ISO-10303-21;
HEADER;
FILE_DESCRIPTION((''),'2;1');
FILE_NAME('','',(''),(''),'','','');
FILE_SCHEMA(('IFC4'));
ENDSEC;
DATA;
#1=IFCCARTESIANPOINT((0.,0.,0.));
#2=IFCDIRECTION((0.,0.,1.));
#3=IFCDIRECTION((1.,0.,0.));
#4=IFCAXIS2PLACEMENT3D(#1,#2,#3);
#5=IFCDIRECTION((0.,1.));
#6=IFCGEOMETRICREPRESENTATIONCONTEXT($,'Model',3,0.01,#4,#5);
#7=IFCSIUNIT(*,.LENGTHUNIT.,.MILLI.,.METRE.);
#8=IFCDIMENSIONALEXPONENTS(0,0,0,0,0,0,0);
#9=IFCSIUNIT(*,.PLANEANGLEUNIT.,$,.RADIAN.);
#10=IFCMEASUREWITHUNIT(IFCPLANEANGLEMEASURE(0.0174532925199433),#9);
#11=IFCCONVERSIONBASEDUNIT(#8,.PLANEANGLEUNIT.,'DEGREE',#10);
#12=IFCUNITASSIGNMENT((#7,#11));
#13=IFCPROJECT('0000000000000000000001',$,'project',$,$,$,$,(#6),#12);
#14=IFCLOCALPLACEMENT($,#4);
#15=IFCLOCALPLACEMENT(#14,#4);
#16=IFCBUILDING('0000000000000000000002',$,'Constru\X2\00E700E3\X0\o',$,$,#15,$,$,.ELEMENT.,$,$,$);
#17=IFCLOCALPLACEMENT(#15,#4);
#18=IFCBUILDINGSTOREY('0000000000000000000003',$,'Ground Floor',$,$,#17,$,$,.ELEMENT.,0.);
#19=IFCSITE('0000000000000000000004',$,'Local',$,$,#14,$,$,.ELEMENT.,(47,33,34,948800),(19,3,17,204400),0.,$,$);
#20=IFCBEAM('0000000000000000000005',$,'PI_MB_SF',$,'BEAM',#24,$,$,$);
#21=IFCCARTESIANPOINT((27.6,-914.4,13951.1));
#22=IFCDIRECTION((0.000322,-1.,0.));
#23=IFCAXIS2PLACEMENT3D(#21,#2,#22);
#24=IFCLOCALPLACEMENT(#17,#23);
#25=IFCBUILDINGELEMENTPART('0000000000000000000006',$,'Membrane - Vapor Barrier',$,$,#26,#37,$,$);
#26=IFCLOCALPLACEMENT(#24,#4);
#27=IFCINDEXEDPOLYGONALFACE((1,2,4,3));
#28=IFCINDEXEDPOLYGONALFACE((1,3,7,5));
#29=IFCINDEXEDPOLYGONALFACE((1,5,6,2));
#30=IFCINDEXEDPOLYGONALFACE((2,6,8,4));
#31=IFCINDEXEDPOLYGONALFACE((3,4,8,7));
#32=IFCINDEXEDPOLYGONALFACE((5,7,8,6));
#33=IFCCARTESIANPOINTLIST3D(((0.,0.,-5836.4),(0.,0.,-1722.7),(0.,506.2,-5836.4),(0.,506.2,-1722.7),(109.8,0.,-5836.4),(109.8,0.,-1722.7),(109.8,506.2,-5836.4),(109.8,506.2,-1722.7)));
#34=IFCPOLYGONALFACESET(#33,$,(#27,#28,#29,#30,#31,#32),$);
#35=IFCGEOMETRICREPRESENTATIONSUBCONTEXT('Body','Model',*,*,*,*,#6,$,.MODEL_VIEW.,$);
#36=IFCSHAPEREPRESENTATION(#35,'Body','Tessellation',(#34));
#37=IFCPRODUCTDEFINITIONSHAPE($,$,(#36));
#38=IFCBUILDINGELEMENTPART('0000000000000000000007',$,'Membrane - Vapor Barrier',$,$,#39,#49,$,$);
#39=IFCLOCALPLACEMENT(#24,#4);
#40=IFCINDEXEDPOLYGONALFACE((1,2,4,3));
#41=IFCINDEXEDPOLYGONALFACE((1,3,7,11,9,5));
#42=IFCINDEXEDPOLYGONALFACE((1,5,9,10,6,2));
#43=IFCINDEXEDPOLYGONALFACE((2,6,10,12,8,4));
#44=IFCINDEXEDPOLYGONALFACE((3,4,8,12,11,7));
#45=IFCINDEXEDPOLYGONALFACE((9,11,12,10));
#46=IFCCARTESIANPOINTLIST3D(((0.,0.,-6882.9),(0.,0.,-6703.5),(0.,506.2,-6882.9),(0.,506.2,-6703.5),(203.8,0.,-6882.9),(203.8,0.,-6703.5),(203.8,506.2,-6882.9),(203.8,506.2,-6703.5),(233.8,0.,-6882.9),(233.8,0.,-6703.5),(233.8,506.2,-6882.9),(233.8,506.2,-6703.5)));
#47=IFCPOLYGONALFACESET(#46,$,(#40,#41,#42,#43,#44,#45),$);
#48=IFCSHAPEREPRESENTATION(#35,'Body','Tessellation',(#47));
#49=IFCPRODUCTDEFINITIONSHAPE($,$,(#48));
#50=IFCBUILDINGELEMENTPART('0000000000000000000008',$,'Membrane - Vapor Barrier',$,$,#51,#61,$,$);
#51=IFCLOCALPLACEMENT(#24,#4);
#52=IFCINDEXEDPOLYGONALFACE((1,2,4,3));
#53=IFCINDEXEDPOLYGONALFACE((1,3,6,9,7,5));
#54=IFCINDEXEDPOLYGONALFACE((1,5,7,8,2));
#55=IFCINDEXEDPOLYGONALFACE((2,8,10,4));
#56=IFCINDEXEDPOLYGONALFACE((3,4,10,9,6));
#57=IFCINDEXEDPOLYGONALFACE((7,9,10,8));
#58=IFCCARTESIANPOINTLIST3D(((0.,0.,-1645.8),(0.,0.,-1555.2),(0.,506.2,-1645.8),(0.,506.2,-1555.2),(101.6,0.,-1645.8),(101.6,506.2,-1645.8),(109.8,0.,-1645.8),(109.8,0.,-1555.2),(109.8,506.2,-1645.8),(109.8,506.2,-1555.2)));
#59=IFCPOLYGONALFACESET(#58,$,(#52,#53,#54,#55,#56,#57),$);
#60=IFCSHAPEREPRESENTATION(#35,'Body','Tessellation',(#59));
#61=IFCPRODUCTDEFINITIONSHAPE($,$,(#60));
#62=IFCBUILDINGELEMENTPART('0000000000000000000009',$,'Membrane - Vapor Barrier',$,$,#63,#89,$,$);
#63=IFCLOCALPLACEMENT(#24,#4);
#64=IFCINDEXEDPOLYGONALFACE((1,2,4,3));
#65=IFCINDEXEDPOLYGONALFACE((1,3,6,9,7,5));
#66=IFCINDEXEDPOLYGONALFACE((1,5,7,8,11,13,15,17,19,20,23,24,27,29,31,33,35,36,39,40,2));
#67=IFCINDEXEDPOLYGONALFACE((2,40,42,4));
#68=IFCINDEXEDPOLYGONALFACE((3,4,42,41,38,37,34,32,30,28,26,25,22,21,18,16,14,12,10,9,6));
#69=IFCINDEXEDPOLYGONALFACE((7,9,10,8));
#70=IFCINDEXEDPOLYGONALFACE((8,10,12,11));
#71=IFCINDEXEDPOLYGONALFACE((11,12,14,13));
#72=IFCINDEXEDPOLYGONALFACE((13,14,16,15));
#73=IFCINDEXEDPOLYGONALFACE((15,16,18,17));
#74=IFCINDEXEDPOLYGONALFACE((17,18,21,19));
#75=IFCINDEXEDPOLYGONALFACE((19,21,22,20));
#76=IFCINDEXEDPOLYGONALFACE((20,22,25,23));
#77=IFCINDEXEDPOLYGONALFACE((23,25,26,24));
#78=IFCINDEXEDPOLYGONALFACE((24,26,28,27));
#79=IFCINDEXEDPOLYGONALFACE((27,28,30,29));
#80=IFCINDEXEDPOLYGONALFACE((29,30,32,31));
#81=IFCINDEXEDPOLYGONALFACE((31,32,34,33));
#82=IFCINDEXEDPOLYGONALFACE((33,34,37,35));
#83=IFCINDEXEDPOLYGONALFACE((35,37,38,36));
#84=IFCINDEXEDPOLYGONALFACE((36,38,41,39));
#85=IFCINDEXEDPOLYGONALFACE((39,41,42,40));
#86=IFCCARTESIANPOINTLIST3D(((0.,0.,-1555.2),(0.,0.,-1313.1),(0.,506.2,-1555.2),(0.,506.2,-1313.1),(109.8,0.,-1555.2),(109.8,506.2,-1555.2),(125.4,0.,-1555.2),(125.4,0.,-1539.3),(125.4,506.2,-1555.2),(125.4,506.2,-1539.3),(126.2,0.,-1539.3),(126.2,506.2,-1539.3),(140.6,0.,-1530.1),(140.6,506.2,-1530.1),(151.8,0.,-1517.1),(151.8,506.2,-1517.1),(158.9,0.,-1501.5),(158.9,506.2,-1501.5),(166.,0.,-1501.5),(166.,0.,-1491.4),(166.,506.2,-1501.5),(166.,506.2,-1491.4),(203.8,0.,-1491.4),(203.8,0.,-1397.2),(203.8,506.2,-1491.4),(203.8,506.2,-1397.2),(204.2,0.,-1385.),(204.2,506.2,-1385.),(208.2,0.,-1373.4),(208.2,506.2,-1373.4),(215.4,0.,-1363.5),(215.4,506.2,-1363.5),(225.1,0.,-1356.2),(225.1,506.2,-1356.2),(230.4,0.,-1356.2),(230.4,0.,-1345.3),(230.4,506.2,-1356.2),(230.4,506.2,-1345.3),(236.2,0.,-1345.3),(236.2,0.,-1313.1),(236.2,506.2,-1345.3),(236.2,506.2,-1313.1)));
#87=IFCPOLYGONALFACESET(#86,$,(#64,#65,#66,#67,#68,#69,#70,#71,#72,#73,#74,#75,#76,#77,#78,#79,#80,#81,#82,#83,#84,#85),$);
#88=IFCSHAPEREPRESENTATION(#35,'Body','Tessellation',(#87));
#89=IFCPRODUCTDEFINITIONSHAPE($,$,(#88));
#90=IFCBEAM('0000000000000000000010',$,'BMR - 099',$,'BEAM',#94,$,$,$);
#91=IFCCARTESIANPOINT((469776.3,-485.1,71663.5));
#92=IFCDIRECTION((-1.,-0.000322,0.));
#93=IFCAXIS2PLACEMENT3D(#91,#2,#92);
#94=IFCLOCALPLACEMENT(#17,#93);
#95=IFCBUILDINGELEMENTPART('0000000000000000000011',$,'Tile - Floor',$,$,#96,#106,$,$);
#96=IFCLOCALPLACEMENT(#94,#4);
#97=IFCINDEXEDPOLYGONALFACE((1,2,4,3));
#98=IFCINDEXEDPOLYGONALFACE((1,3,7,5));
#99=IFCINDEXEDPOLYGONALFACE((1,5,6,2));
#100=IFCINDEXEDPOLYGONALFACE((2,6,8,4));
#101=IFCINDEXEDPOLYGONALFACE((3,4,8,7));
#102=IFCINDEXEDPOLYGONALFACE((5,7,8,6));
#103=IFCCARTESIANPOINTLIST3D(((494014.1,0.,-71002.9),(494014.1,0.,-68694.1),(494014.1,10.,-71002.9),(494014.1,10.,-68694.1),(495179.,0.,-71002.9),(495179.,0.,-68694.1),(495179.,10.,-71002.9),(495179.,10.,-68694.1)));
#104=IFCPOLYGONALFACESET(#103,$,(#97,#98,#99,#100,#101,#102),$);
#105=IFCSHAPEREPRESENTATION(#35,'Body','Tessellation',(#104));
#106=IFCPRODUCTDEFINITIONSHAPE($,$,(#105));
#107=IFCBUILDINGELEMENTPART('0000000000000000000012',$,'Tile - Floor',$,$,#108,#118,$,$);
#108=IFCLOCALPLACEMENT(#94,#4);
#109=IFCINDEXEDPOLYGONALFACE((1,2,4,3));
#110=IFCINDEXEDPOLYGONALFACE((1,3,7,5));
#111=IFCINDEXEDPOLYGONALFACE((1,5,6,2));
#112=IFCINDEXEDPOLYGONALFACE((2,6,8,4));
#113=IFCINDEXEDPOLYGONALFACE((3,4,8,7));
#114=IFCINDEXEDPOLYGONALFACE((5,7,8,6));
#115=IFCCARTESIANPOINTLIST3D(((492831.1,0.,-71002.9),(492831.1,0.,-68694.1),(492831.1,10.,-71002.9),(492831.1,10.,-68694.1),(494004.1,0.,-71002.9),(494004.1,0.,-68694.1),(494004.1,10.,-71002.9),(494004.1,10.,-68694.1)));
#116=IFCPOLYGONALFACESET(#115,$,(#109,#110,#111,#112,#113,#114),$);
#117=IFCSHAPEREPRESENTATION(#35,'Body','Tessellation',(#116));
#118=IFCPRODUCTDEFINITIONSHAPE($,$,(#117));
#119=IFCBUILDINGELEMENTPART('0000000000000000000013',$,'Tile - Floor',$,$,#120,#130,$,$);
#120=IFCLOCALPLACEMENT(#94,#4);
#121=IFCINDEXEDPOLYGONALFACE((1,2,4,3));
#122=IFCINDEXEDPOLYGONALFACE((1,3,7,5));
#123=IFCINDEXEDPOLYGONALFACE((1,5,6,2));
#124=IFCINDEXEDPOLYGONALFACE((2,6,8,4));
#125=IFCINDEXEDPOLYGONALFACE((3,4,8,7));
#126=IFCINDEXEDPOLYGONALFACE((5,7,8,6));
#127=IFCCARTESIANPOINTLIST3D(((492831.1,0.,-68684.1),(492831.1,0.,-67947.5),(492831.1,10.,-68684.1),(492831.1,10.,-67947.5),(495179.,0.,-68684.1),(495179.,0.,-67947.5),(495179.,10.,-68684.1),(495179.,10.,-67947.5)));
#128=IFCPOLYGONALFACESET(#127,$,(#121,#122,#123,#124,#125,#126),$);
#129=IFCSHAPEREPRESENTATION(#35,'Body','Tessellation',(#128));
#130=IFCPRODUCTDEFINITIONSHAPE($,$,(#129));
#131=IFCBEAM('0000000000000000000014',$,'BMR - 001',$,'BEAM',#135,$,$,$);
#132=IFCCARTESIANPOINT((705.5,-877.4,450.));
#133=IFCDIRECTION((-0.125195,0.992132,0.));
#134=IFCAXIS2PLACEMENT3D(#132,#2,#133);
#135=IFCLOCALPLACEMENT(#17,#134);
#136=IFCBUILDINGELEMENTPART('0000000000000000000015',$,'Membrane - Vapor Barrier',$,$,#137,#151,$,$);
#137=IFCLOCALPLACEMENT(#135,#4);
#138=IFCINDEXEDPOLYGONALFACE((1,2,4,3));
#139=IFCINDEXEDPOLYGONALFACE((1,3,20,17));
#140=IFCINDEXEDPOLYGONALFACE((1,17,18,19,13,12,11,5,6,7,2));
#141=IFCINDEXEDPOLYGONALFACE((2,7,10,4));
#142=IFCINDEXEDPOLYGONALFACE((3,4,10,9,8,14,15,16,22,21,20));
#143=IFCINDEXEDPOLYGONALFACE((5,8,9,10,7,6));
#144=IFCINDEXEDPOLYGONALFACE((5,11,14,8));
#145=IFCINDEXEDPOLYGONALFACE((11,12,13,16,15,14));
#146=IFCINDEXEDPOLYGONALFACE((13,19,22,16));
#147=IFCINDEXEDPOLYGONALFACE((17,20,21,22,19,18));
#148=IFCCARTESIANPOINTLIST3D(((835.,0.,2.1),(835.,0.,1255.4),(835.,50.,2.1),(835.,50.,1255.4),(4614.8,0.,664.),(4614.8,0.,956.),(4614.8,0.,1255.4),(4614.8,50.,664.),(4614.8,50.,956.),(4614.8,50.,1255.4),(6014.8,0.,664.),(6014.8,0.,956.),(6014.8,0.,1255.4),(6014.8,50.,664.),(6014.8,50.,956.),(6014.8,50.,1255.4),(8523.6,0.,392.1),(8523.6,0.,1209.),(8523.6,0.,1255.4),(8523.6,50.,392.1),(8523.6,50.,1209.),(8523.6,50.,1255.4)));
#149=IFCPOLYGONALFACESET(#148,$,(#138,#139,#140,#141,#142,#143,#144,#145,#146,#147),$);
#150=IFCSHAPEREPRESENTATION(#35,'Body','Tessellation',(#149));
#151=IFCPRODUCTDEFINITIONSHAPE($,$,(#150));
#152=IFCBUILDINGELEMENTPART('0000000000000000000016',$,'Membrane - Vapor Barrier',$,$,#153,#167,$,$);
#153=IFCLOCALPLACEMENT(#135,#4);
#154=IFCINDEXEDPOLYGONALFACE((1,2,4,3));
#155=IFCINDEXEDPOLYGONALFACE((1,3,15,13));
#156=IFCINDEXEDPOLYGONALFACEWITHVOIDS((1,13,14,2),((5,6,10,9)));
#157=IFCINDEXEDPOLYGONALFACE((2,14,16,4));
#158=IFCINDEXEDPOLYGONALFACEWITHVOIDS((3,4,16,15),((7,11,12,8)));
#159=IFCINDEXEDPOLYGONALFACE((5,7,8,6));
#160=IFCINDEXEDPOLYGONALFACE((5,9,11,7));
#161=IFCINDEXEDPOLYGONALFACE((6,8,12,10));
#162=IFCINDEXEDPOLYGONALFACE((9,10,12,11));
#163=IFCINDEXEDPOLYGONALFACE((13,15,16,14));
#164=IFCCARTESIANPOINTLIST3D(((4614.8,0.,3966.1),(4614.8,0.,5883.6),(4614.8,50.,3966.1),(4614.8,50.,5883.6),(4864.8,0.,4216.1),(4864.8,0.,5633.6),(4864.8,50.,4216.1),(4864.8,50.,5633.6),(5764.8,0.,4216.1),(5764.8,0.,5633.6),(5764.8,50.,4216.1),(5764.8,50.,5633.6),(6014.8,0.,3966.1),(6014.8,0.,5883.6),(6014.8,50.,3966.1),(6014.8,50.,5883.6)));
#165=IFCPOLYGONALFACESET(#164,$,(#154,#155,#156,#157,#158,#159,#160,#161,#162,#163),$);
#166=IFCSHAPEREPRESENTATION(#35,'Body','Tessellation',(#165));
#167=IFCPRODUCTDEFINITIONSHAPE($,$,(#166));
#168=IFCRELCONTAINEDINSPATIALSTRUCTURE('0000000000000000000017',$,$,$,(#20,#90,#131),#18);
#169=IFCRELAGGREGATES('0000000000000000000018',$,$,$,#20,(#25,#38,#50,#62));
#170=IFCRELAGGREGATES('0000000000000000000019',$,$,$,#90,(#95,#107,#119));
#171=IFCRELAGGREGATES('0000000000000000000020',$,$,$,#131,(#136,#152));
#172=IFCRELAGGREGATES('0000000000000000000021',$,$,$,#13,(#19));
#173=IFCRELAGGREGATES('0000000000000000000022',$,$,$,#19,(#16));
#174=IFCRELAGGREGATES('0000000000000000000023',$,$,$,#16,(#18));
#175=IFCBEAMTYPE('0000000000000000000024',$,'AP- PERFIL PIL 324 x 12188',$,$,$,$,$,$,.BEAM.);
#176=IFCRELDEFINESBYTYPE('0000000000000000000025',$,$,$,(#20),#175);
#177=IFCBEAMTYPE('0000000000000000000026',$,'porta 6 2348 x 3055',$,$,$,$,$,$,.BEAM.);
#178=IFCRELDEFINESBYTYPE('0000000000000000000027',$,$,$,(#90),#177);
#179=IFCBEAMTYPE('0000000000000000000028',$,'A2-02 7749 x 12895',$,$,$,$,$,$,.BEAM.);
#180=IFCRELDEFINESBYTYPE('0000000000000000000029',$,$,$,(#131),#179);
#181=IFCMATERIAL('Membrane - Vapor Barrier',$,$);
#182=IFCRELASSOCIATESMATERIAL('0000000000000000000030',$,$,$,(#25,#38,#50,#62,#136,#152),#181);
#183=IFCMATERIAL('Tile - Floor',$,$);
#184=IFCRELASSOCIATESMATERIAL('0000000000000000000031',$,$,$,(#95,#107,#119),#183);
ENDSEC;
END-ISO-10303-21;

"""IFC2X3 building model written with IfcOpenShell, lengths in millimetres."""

from ifc_helpers import new_model, entity, si_unit, converted_unit, point, direction, frame, frame_2d, origin_with_axes, place, context, subcontext, project, spatial, polyline, circle_curve, parameter, trimmed, segment, composite_curve, outline, extrude, material, type_object, element, aggregate, save


model = new_model("IFC2X3")

# Units and contexts
model_context = context("Model", 3, precision=0.01, world=origin_with_axes(), true_north=direction((0.0, 1.0)))
body_context = subcontext(model_context, "Body", "Model", "MODEL_VIEW")
ifc_project = project(units=[si_unit("LENGTHUNIT", "METRE", prefix="MILLI"), converted_unit("PLANEANGLEUNIT", "DEGREE", entity("IfcPlaneAngleMeasure", 0.0174532925199433), si_unit("PLANEANGLEUNIT", "RADIAN"), dimensions=[0, 0, 0, 0, 0, 0, 0])], contexts=[model_context])

# Site, building, storey
site_placement = place(None, origin_with_axes())
site = spatial("IfcSite", under=ifc_project, at=site_placement, Name="Local", CompositionType="ELEMENT", RefLatitude=(47, 33, 34, 948800), RefLongitude=(19, 3, 17, 204400), RefElevation=0.0)
building_placement = place(site_placement, origin_with_axes())
building = spatial("IfcBuilding", under=site, at=building_placement, Name="Construção", CompositionType="ELEMENT")
storey_placement = place(building_placement, origin_with_axes())
storey = spatial("IfcBuildingStorey", under=building, at=storey_placement, Name="Ground Floor", CompositionType="ELEMENT", Elevation=0.0)

# Shared definitions
ifc_material_1 = material(Name="Membrane - Vapor Barrier")

# Shared definitions
ifc_material_2 = material(Name="Tile - Floor")

# Beams, building element parts
beam_type_1 = type_object("IfcBeamType", Name="AP- PERFIL PIL 324 x 12188", PredefinedType="BEAM")
beam_1_placement = place(storey_placement, frame((27.6, -914.4, 13951.1), z_axis=(0.0, 0.0, 1.0), x_axis=(0.000322, -1.0, 0.0)))
beam_1 = element("IfcBeam", 1, at=beam_1_placement, inside=storey, type_object=beam_type_1, Name="PI_MB_SF", ObjectType="BEAM")
building_element_part_1_placement = place(beam_1_placement, origin_with_axes())
building_element_part_1 = element("IfcBuildingElementPart", 2, at=building_element_part_1_placement, material=ifc_material_1, Name="Membrane - Vapor Barrier", context=body_context, shape_type="SweptSolid", body=[
    extrude(outline(polyline([(109.8, -1722.7), (0.0, -1722.7), (0.0, -5836.4), (109.8, -5836.4), (109.8, -1722.7)])), frame((0.0, 506.2, 0.0), z_axis=(0.0, -1.0, 0.0), x_axis=(1.0, 0.0, 0.0)), (0.0, 0.0, 1.0), 506.2),
])
building_element_part_2_placement = place(beam_1_placement, origin_with_axes())
building_element_part_2 = element("IfcBuildingElementPart", 3, at=building_element_part_2_placement, material=ifc_material_1, Name="Membrane - Vapor Barrier", context=body_context, shape_type="SweptSolid", body=[
    extrude(outline(polyline([(233.8, -6882.9), (233.8, -6703.5), (203.8, -6703.5), (0.0, -6703.5), (0.0, -6882.9), (203.8, -6882.9), (233.8, -6882.9)])), frame((0.0, 506.2, 0.0), z_axis=(0.0, -1.0, 0.0), x_axis=(1.0, 0.0, 0.0)), (0.0, 0.0, 1.0), 506.2),
])
building_element_part_3_placement = place(beam_1_placement, origin_with_axes())
building_element_part_3 = element("IfcBuildingElementPart", 4, at=building_element_part_3_placement, material=ifc_material_1, Name="Membrane - Vapor Barrier", context=body_context, shape_type="SweptSolid", body=[
    extrude(outline(polyline([(0.0, -1645.8), (101.6, -1645.8), (109.8, -1645.8), (109.8, -1555.2), (0.0, -1555.2), (0.0, -1645.8)])), frame((0.0, 506.2, 0.0), z_axis=(0.0, -1.0, 0.0), x_axis=(1.0, 0.0, 0.0)), (0.0, 0.0, 1.0), 506.2),
])
building_element_part_4_placement = place(beam_1_placement, origin_with_axes())
building_element_part_4 = element("IfcBuildingElementPart", 5, at=building_element_part_4_placement, material=ifc_material_1, Name="Membrane - Vapor Barrier", context=body_context, shape_type="SweptSolid", body=[
    extrude(outline(composite_curve([segment(polyline([(0.0, -1555.2), (109.8, -1555.2), (125.4, -1555.2), (125.4, -1539.3), (126.2, -1539.3)]), True, "CONTINUOUS"), segment(trimmed(circle_curve(frame_2d((101.8, -1485.2), x_axis=(0.411627, -0.911352)), 59.4), [point((126.2, -1539.3)), parameter(0.0)], [point((158.9, -1501.5)), parameter(49.79606)], True, "CARTESIAN"), True, "CONTINUOUS"), segment(polyline([(158.9, -1501.5), (166.0, -1501.5), (166.0, -1491.4), (203.8, -1491.4), (203.8, -1397.2)]), True, "CONTINUOUS"), segment(trimmed(circle_curve(frame_2d((245.0, -1392.6), x_axis=(-0.480333, 0.877086)), 41.5), [point((203.8, -1397.2)), parameter(67.594129)], [point((225.1, -1356.2)), parameter(0.0)], False, "CARTESIAN"), True, "CONTINUOUS"), segment(polyline([(225.1, -1356.2), (230.4, -1356.2), (230.4, -1345.3), (236.2, -1345.3), (236.2, -1313.1), (0.0, -1313.1), (0.0, -1555.2)]), True, "CONTINUOUS")], self_intersect=False)), frame((0.0, 506.2, 0.0), z_axis=(0.0, -1.0, 0.0), x_axis=(1.0, 0.0, 0.0)), (0.0, 0.0, 1.0), 506.2),
])
aggregate(beam_1, [building_element_part_1, building_element_part_2, building_element_part_3, building_element_part_4])
beam_type_2 = type_object("IfcBeamType", Name="porta 6 2348 x 3055", PredefinedType="BEAM")
beam_2_placement = place(storey_placement, frame((469776.3, -485.1, 71663.5), z_axis=(0.0, 0.0, 1.0), x_axis=(-1.0, -0.000322, 0.0)))
beam_2 = element("IfcBeam", 6, at=beam_2_placement, inside=storey, type_object=beam_type_2, Name="BMR - 099", ObjectType="BEAM")
building_element_part_5_placement = place(beam_2_placement, origin_with_axes())
building_element_part_5 = element("IfcBuildingElementPart", 7, at=building_element_part_5_placement, material=ifc_material_2, Name="Tile - Floor", context=body_context, shape_type="SweptSolid", body=[
    extrude(outline(polyline([(494014.1, -68694.1), (494014.1, -71002.9), (495179.0, -71002.9), (495179.0, -68694.1), (494014.1, -68694.1)])), frame((0.0, 10.0, 0.0), z_axis=(0.0, -1.0, 0.0), x_axis=(1.0, 0.0, 0.0)), (0.0, 0.0, 1.0), 10.0),
])
building_element_part_6_placement = place(beam_2_placement, origin_with_axes())
building_element_part_6 = element("IfcBuildingElementPart", 8, at=building_element_part_6_placement, material=ifc_material_2, Name="Tile - Floor", context=body_context, shape_type="SweptSolid", body=[
    extrude(outline(polyline([(492831.1, -68694.1), (492831.1, -71002.9), (494004.1, -71002.9), (494004.1, -68694.1), (492831.1, -68694.1)])), frame((0.0, 10.0, 0.0), z_axis=(0.0, -1.0, 0.0), x_axis=(1.0, 0.0, 0.0)), (0.0, 0.0, 1.0), 10.0),
])
building_element_part_7_placement = place(beam_2_placement, origin_with_axes())
building_element_part_7 = element("IfcBuildingElementPart", 9, at=building_element_part_7_placement, material=ifc_material_2, Name="Tile - Floor", context=body_context, shape_type="SweptSolid", body=[
    extrude(outline(polyline([(492831.1, -67947.5), (492831.1, -68684.1), (495179.0, -68684.1), (495179.0, -67947.5), (492831.1, -67947.5)])), frame((0.0, 10.0, 0.0), z_axis=(0.0, -1.0, 0.0), x_axis=(1.0, 0.0, 0.0)), (0.0, 0.0, 1.0), 10.0),
])
aggregate(beam_2, [building_element_part_5, building_element_part_6, building_element_part_7])
beam_type_3 = type_object("IfcBeamType", Name="A2-02 7749 x 12895", PredefinedType="BEAM")
beam_3_placement = place(storey_placement, frame((705.5, -877.4, 450.0), z_axis=(0.0, 0.0, 1.0), x_axis=(-0.125195, 0.992132, 0.0)))
beam_3 = element("IfcBeam", 10, at=beam_3_placement, inside=storey, type_object=beam_type_3, Name="BMR - 001", ObjectType="BEAM")
building_element_part_8_placement = place(beam_3_placement, origin_with_axes())
building_element_part_8 = element("IfcBuildingElementPart", 11, at=building_element_part_8_placement, material=ifc_material_1, Name="Membrane - Vapor Barrier", context=body_context, shape_type="SweptSolid", body=[
    extrude(outline(polyline([(4614.8, 1255.4), (835.0, 1255.4), (835.0, 2.1), (8523.6, 392.1), (8523.6, 1209.0), (8523.6, 1255.4), (6014.8, 1255.4), (6014.8, 956.0), (6014.8, 664.0), (4614.8, 664.0), (4614.8, 956.0), (4614.8, 1255.4)])), frame((0.0, 50.0, 0.0), z_axis=(0.0, -1.0, 0.0), x_axis=(1.0, 0.0, 0.0)), (0.0, 0.0, 1.0), 50.0),
])
building_element_part_9_placement = place(beam_3_placement, origin_with_axes())
building_element_part_9 = element("IfcBuildingElementPart", 12, at=building_element_part_9_placement, material=ifc_material_1, Name="Membrane - Vapor Barrier", context=body_context, shape_type="SweptSolid", body=[
    extrude(outline(polyline([(4614.8, 3966.1), (6014.8, 3966.1), (6014.8, 5883.6), (4614.8, 5883.6), (4614.8, 3966.1)]), holes=[polyline([(4864.8, 4216.1), (4864.8, 5633.6), (5764.8, 5633.6), (5764.8, 4216.1), (4864.8, 4216.1)])]), frame((0.0, 50.0, 0.0), z_axis=(0.0, -1.0, 0.0), x_axis=(1.0, 0.0, 0.0)), (0.0, 0.0, 1.0), 50.0),
])
aggregate(beam_3, [building_element_part_8, building_element_part_9])

save(model, "model.ifc")
